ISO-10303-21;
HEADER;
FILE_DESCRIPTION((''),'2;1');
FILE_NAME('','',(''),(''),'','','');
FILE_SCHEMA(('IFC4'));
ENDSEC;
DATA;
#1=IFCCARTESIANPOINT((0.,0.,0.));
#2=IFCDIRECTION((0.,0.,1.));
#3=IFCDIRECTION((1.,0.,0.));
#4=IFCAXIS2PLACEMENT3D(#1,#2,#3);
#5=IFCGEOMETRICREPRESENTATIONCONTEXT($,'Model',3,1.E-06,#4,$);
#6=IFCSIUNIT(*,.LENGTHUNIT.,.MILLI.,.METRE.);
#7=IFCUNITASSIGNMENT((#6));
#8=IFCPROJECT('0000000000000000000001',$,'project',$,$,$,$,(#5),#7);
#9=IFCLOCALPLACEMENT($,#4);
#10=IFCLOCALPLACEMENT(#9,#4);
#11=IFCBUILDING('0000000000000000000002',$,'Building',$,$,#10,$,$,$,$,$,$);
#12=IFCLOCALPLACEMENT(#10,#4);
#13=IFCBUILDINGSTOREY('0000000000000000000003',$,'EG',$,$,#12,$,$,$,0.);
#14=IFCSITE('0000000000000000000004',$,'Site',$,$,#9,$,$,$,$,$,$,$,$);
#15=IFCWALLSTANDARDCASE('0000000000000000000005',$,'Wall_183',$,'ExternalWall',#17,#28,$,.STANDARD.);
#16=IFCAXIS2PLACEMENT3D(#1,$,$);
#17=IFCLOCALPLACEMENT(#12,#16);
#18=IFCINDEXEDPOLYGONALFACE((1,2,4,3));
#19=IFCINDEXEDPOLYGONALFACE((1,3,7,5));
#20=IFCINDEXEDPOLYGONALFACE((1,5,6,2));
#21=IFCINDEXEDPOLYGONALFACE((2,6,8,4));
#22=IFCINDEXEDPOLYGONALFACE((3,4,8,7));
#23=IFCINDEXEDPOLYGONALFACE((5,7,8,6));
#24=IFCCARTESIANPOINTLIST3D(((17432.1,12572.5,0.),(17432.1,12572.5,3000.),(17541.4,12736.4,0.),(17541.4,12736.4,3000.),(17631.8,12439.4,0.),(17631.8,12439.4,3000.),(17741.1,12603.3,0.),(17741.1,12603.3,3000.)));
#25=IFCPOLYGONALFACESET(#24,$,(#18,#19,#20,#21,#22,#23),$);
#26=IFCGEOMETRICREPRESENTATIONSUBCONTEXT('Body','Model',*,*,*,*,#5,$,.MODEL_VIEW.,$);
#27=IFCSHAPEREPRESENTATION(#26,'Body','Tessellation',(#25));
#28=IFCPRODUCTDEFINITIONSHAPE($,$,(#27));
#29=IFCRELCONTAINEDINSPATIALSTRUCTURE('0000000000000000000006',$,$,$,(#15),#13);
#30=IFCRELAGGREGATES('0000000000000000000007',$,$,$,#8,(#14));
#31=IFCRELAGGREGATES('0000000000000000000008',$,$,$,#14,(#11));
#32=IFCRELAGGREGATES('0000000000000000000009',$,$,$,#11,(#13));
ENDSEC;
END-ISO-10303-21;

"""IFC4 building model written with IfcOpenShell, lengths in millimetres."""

from ifc_helpers import new_model, si_unit, frame, origin_with_axes, place, context, subcontext, project, spatial, rectangle, extrude, element, save


model = new_model("IFC4")

# Units and contexts
model_context = context("Model", 3, precision=1e-06, world=origin_with_axes())
body_context = subcontext(model_context, "Body", "Model", "MODEL_VIEW")
ifc_project = project(units=[si_unit("LENGTHUNIT", "METRE", prefix="MILLI")], contexts=[model_context])

# Site, building, storey
site_placement = place(None, origin_with_axes())
site = spatial("IfcSite", under=ifc_project, at=site_placement, Name="Site")
building_placement = place(site_placement, origin_with_axes())
building = spatial("IfcBuilding", under=site, at=building_placement, Name="Building")
storey_placement = place(building_placement, origin_with_axes())
storey = spatial("IfcBuildingStorey", under=building, at=storey_placement, Name="EG", Elevation=0.0)

# Wall
wall_1_placement = place(storey_placement, origin_with_axes())
element("IfcWallStandardCase", 1, at=wall_1_placement, inside=storey, Name="Wall_183", ObjectType="ExternalWall", PredefinedType="STANDARD", context=body_context, shape_type="SweptSolid", body=[
    extrude(rectangle(XDim=197.0, YDim=240.0), frame((17586.6, 12587.9, 0.0), z_axis=(0.0, 0.0, 1.0), x_axis=(-0.5547, -0.83205, 0.0)), (0.0, 0.0, 1.0), 3000.0),
])

save(model, "model.ifc")
